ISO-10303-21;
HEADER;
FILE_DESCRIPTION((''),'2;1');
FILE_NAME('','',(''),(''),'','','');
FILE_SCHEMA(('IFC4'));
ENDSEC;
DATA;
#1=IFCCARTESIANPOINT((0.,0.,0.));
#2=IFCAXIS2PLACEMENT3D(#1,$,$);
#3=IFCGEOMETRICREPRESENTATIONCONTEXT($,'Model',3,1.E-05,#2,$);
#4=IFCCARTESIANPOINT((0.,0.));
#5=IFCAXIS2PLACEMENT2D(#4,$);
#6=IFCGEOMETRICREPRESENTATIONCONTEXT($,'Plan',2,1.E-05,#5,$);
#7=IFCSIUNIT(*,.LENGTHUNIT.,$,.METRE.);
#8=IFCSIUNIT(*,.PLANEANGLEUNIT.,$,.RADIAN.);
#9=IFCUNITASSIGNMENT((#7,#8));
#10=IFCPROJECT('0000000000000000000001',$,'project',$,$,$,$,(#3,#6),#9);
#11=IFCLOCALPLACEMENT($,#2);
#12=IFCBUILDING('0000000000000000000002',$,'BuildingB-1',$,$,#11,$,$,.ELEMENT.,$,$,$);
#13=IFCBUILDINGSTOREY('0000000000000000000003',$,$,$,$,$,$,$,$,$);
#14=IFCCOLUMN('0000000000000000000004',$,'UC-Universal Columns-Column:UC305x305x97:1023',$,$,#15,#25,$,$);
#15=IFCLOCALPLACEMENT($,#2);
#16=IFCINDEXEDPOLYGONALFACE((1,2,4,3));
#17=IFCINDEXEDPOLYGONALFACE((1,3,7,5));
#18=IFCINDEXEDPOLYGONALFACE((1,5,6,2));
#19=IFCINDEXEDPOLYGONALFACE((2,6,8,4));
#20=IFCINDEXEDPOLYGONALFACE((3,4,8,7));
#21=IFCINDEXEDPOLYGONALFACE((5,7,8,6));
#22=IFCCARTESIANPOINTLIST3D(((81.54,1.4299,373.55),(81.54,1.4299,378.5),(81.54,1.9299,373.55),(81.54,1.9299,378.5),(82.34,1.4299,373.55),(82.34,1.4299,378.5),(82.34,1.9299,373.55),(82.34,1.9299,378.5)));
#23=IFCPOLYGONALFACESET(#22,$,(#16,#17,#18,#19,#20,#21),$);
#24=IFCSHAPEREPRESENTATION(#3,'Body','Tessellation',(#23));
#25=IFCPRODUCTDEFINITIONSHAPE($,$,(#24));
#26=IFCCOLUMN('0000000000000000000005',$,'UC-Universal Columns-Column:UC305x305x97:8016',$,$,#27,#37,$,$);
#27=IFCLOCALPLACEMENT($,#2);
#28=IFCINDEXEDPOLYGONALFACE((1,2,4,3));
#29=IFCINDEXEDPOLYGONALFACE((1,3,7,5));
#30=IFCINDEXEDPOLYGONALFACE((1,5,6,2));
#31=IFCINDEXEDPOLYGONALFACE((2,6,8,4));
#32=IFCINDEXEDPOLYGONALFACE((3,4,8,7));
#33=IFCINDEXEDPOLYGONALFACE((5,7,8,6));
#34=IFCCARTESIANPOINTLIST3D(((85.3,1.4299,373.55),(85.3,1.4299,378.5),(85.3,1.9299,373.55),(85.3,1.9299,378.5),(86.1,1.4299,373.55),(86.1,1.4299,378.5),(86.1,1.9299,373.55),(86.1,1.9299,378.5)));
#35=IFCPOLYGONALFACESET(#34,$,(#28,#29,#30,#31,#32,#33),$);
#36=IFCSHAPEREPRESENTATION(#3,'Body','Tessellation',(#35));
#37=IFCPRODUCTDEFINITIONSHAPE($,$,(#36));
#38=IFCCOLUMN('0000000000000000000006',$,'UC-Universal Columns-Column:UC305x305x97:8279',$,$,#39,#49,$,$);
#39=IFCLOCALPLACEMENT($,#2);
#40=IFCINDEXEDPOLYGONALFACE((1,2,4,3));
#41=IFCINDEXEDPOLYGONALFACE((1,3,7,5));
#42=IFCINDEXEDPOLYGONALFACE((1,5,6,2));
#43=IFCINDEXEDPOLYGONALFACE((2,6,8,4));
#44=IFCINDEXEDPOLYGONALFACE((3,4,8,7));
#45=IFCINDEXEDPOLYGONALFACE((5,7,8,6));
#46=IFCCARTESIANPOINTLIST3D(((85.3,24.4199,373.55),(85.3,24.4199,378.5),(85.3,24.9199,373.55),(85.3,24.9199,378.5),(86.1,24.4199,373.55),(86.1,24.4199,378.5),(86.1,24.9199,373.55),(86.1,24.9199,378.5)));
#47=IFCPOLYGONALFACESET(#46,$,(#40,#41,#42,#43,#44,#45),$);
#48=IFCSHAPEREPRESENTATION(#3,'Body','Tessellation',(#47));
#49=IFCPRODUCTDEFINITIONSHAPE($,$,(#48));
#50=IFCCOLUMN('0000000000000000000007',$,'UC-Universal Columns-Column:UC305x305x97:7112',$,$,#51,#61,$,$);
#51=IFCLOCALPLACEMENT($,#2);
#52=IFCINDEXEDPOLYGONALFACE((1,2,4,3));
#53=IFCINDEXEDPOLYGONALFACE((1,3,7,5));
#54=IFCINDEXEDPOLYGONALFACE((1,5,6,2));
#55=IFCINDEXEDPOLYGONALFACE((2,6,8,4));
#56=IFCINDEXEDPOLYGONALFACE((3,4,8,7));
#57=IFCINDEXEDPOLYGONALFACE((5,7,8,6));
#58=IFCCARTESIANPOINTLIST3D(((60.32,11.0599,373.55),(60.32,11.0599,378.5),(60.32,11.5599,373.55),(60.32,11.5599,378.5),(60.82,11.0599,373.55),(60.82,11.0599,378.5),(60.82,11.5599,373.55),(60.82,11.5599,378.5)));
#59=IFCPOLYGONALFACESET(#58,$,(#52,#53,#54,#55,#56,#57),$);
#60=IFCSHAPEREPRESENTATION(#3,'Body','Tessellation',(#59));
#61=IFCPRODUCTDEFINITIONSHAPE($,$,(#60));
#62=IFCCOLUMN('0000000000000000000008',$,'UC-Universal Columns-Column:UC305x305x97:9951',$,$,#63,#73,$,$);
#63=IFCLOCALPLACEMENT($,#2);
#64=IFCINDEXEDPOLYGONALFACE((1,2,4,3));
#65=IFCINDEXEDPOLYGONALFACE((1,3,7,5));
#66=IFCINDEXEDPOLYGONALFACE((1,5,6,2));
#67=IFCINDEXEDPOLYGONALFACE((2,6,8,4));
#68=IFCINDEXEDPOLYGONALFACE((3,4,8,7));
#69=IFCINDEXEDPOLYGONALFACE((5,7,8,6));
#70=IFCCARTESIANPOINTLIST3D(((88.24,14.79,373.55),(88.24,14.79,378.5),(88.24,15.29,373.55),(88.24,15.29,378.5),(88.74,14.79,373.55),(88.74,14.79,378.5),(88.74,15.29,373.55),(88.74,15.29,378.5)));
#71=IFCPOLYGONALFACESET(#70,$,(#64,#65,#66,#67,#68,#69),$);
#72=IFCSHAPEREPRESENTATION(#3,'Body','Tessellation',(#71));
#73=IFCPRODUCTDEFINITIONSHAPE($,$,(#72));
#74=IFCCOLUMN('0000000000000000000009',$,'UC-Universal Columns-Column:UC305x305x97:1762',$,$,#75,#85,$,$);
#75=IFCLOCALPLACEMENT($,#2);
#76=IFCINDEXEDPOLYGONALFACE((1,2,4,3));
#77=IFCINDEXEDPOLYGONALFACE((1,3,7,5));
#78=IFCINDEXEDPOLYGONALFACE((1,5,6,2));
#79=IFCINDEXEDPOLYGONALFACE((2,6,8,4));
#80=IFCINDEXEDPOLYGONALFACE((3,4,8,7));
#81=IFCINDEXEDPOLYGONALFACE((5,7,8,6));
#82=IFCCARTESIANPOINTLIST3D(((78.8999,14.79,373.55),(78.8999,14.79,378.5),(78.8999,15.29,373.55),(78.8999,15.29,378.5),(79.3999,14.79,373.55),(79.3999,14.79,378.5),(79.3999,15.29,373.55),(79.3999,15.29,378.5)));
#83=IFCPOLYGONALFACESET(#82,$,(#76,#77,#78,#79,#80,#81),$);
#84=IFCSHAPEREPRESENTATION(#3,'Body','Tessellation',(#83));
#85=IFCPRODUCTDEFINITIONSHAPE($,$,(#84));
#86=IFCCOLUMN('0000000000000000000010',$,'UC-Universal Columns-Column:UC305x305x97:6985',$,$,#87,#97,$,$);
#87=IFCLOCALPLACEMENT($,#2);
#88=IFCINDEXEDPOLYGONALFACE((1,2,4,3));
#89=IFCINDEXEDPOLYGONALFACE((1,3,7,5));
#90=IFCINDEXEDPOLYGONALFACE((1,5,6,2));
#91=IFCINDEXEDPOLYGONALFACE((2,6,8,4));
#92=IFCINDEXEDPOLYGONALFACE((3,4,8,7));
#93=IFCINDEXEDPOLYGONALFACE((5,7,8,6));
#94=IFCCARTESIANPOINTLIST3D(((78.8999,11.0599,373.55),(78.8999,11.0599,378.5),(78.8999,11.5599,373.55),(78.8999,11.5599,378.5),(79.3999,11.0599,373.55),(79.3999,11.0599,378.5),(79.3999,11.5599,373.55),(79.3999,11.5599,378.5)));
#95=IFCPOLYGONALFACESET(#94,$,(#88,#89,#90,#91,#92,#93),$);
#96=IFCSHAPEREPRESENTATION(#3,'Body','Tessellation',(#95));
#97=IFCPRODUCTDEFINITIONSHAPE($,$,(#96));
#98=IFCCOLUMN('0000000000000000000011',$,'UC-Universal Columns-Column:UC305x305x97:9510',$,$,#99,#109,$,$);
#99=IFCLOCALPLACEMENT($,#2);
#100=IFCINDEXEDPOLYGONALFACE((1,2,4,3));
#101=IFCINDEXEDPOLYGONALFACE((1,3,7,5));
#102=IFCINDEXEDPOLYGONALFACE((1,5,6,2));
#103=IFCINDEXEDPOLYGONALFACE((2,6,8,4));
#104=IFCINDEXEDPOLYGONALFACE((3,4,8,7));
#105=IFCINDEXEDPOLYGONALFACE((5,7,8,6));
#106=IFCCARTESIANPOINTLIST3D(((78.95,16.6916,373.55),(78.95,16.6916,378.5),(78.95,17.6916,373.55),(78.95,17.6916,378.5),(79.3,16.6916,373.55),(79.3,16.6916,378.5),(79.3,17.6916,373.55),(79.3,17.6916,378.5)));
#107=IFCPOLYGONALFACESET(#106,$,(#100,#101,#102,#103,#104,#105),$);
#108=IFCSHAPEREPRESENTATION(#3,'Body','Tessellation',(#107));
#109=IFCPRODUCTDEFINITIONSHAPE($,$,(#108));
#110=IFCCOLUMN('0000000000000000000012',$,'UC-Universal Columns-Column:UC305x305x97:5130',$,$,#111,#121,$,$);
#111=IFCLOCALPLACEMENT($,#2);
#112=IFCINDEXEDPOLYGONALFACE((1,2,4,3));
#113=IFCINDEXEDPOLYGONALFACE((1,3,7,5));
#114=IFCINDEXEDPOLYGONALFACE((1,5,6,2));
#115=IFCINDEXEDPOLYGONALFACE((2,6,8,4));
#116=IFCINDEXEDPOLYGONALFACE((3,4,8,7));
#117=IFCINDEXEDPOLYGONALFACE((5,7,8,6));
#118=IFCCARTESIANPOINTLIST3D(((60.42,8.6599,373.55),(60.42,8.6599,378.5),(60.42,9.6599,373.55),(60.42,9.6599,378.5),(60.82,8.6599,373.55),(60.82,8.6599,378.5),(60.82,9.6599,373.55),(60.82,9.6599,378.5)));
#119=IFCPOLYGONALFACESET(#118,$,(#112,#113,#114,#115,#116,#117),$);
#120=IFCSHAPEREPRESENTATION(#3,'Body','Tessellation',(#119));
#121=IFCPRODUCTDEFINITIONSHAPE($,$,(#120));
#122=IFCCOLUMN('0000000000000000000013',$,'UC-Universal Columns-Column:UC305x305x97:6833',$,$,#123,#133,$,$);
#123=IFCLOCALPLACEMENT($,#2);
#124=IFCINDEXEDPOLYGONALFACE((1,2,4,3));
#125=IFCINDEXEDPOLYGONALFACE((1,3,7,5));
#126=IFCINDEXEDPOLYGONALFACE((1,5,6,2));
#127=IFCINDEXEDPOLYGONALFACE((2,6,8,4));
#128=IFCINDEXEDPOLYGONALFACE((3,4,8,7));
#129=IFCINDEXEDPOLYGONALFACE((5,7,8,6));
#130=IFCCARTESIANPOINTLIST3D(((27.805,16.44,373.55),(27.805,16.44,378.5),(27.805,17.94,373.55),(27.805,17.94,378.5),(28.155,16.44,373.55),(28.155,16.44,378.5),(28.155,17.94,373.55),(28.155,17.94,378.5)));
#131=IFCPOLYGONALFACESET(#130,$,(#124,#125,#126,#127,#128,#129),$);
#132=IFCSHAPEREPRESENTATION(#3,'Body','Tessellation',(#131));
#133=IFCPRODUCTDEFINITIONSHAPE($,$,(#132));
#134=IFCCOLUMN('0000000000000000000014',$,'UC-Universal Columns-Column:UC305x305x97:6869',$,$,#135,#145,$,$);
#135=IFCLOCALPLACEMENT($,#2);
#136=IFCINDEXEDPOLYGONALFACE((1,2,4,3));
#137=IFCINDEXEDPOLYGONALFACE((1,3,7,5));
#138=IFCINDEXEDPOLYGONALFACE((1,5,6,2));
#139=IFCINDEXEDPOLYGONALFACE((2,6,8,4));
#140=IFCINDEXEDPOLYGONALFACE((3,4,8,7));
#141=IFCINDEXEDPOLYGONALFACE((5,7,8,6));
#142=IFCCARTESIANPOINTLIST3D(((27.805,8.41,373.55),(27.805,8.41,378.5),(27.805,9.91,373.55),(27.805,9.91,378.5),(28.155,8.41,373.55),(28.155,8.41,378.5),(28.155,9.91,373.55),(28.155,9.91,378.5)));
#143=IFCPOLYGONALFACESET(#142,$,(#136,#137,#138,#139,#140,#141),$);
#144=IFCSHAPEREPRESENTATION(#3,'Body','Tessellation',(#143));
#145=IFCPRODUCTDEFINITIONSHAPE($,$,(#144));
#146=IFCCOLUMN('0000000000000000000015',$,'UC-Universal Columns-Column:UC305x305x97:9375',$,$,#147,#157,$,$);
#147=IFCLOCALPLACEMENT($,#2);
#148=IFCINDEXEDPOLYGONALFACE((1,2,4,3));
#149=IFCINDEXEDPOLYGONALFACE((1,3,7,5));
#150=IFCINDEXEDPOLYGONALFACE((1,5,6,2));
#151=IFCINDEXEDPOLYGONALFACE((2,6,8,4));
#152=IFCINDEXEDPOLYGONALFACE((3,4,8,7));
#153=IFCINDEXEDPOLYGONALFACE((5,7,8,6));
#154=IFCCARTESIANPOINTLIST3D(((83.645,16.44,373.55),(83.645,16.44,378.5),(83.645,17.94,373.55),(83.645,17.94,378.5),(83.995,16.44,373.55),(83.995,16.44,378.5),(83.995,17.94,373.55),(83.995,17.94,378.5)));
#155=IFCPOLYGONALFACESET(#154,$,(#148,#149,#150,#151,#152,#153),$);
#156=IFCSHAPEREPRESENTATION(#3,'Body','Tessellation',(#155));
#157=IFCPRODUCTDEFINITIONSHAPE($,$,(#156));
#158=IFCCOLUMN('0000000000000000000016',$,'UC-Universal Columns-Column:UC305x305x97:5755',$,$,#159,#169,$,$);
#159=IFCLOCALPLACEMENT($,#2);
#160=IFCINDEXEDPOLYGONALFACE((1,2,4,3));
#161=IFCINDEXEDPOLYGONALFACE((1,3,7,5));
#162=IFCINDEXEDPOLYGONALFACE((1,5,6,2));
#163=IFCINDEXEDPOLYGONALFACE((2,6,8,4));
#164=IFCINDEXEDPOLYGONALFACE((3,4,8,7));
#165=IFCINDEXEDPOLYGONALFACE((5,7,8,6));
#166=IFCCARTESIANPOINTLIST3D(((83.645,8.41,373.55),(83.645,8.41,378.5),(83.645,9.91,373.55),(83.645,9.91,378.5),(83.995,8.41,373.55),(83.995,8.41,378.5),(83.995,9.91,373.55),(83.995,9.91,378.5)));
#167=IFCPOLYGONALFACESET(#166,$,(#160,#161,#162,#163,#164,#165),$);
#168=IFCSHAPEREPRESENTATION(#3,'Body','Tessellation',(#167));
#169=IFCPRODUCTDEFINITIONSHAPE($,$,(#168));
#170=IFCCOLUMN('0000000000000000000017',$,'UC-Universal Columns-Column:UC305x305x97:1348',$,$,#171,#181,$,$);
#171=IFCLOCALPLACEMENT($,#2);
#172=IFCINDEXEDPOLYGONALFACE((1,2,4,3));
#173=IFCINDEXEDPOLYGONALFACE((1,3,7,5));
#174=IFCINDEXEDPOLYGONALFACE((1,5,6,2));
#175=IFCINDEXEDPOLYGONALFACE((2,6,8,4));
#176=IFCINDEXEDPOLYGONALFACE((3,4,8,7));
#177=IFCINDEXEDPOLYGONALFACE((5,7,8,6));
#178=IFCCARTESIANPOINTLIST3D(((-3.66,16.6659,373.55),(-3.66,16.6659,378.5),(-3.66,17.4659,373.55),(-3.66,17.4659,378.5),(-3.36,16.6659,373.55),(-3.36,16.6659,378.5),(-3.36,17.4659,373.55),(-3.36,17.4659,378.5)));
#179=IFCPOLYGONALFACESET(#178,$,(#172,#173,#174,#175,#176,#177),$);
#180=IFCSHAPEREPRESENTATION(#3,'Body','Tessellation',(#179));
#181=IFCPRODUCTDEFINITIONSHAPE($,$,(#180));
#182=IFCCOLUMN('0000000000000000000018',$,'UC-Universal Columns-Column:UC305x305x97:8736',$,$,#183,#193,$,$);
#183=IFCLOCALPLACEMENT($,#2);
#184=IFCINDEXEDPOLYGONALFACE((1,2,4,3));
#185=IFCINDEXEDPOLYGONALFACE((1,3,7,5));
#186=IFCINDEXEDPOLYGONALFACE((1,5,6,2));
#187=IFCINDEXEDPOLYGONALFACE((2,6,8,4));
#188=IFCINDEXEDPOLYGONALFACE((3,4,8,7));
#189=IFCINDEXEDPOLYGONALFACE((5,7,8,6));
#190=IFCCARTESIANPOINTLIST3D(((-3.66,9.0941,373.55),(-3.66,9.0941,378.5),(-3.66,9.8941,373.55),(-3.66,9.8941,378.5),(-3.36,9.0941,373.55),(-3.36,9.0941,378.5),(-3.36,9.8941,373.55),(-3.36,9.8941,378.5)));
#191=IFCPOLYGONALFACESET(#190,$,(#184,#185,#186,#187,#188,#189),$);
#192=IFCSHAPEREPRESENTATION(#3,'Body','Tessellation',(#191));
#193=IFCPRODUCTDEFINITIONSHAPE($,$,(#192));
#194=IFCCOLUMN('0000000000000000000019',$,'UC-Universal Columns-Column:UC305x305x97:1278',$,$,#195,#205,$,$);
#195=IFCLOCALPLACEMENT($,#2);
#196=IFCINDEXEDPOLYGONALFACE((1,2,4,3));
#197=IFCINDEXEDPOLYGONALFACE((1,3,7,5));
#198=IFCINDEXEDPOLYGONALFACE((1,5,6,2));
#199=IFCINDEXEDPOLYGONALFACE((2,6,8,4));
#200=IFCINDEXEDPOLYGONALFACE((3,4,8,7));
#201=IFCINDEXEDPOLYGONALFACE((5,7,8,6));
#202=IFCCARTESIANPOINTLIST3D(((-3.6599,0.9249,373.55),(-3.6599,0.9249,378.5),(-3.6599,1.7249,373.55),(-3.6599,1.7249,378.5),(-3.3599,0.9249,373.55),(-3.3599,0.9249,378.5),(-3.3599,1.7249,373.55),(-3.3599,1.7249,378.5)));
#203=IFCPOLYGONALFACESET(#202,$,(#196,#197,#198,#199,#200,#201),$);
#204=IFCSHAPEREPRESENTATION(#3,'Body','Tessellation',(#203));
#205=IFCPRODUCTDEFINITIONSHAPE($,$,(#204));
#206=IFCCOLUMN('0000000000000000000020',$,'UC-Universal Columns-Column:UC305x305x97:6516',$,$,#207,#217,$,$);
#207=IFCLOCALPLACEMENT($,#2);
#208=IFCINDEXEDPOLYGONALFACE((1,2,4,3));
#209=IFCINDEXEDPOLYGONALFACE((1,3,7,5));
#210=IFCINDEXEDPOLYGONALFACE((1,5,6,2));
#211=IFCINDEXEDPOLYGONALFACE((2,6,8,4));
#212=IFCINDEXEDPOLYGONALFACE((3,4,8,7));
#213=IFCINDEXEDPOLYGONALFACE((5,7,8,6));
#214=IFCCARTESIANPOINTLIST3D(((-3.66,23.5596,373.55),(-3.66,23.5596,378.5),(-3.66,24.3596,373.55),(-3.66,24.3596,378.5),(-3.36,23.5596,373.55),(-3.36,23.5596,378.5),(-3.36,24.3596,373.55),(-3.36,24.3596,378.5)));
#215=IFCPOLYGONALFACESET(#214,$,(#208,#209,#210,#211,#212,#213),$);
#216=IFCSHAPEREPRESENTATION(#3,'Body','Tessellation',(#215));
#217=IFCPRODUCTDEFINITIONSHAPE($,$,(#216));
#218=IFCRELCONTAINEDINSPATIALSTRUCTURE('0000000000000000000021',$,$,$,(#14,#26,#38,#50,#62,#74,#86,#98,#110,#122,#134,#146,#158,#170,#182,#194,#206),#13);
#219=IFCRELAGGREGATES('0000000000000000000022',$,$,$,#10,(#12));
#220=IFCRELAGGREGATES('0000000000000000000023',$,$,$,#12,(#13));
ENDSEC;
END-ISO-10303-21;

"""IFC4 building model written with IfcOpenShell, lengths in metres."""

from ifc_helpers import new_model, si_unit, origin, origin_2d, place, context, project, spatial, polyline, outline, extrude, element, save


model = new_model("IFC4")

# Units and contexts
model_context = context("Model", 3, precision=1e-05, world=origin())
plan_context = context("Plan", 2, precision=1e-05, world=origin_2d())
ifc_project = project(units=[si_unit("LENGTHUNIT", "METRE"), si_unit("PLANEANGLEUNIT", "RADIAN")], contexts=[model_context, plan_context])

# Building, storey
building_placement = place(None, origin())
building = spatial("IfcBuilding", under=ifc_project, at=building_placement, Name="BuildingB-1", CompositionType="ELEMENT")
storey = spatial("IfcBuildingStorey", under=building)

# Columns
element("IfcColumn", 1, inside=storey, Name="UC-Universal Columns-Column:UC305x305x97:1023", context=model_context, shape_type="SweptSolid", body=[
    extrude(outline(polyline([(81.54, 1.4299, 378.5), (82.34, 1.4299, 378.5), (82.34, 1.9299, 378.5), (81.54, 1.9299, 378.5), (81.54, 1.4299, 378.5)])), None, (0.0, 0.0, -1.0), 4.95),
])
element("IfcColumn", 2, inside=storey, Name="UC-Universal Columns-Column:UC305x305x97:8016", context=model_context, shape_type="SweptSolid", body=[
    extrude(outline(polyline([(86.1, 1.4299, 378.5), (85.3, 1.4299, 378.5), (85.3, 1.9299, 378.5), (86.1, 1.9299, 378.5), (86.1, 1.4299, 378.5)])), None, (0.0, 0.0, -1.0), 4.95),
])
element("IfcColumn", 3, inside=storey, Name="UC-Universal Columns-Column:UC305x305x97:8279", context=model_context, shape_type="SweptSolid", body=[
    extrude(outline(polyline([(86.1, 24.4199, 378.5), (85.3, 24.4199, 378.5), (85.3, 24.9199, 378.5), (86.1, 24.9199, 378.5), (86.1, 24.4199, 378.5)])), None, (0.0, 0.0, -1.0), 4.95),
])
element("IfcColumn", 4, inside=storey, Name="UC-Universal Columns-Column:UC305x305x97:7112", context=model_context, shape_type="SweptSolid", body=[
    extrude(outline(polyline([(60.82, 11.0599, 378.5), (60.32, 11.0599, 378.5), (60.32, 11.5599, 378.5), (60.82, 11.5599, 378.5), (60.82, 11.0599, 378.5)])), None, (0.0, 0.0, -1.0), 4.95),
])
element("IfcColumn", 5, inside=storey, Name="UC-Universal Columns-Column:UC305x305x97:9951", context=model_context, shape_type="SweptSolid", body=[
    extrude(outline(polyline([(88.74, 15.29, 378.5), (88.24, 15.29, 378.5), (88.24, 14.79, 378.5), (88.74, 14.79, 378.5), (88.74, 15.29, 378.5)])), None, (0.0, 0.0, -1.0), 4.95),
])
element("IfcColumn", 6, inside=storey, Name="UC-Universal Columns-Column:UC305x305x97:1762", context=model_context, shape_type="SweptSolid", body=[
    extrude(outline(polyline([(78.8999, 15.29, 378.5), (79.3999, 15.29, 378.5), (79.3999, 14.79, 378.5), (78.8999, 14.79, 378.5), (78.8999, 15.29, 378.5)])), None, (0.0, 0.0, -1.0), 4.95),
])
element("IfcColumn", 7, inside=storey, Name="UC-Universal Columns-Column:UC305x305x97:6985", context=model_context, shape_type="SweptSolid", body=[
    extrude(outline(polyline([(78.8999, 11.0599, 378.5), (79.3999, 11.0599, 378.5), (79.3999, 11.5599, 378.5), (78.8999, 11.5599, 378.5), (78.8999, 11.0599, 378.5)])), None, (0.0, 0.0, -1.0), 4.95),
])
element("IfcColumn", 8, inside=storey, Name="UC-Universal Columns-Column:UC305x305x97:9510", context=model_context, shape_type="SweptSolid", body=[
    extrude(outline(polyline([(79.3, 17.6916, 378.5), (78.95, 17.6916, 378.5), (78.95, 16.6916, 378.5), (79.3, 16.6916, 378.5), (79.3, 17.6916, 378.5)])), None, (0.0, 0.0, -1.0), 4.95),
])
element("IfcColumn", 9, inside=storey, Name="UC-Universal Columns-Column:UC305x305x97:5130", context=model_context, shape_type="SweptSolid", body=[
    extrude(outline(polyline([(60.42, 8.6599, 378.5), (60.82, 8.6599, 378.5), (60.82, 9.6599, 378.5), (60.42, 9.6599, 378.5), (60.42, 8.6599, 378.5)])), None, (0.0, 0.0, -1.0), 4.95),
])
element("IfcColumn", 10, inside=storey, Name="UC-Universal Columns-Column:UC305x305x97:6833", context=model_context, shape_type="SweptSolid", body=[
    extrude(outline(polyline([(28.155, 17.94, 378.5), (27.805, 17.94, 378.5), (27.805, 16.44, 378.5), (28.155, 16.44, 378.5), (28.155, 17.94, 378.5)])), None, (0.0, 0.0, -1.0), 4.95),
])
element("IfcColumn", 11, inside=storey, Name="UC-Universal Columns-Column:UC305x305x97:6869", context=model_context, shape_type="SweptSolid", body=[
    extrude(outline(polyline([(28.155, 9.91, 378.5), (27.805, 9.91, 378.5), (27.805, 8.41, 378.5), (28.155, 8.41, 378.5), (28.155, 9.91, 378.5)])), None, (0.0, 0.0, -1.0), 4.95),
])
element("IfcColumn", 12, inside=storey, Name="UC-Universal Columns-Column:UC305x305x97:9375", context=model_context, shape_type="SweptSolid", body=[
    extrude(outline(polyline([(83.995, 17.94, 378.5), (83.645, 17.94, 378.5), (83.645, 16.44, 378.5), (83.995, 16.44, 378.5), (83.995, 17.94, 378.5)])), None, (0.0, 0.0, -1.0), 4.95),
])
element("IfcColumn", 13, inside=storey, Name="UC-Universal Columns-Column:UC305x305x97:5755", context=model_context, shape_type="SweptSolid", body=[
    extrude(outline(polyline([(83.995, 9.91, 378.5), (83.645, 9.91, 378.5), (83.645, 8.41, 378.5), (83.995, 8.41, 378.5), (83.995, 9.91, 378.5)])), None, (0.0, 0.0, -1.0), 4.95),
])
element("IfcColumn", 14, inside=storey, Name="UC-Universal Columns-Column:UC305x305x97:1348", context=model_context, shape_type="SweptSolid", body=[
    extrude(outline(polyline([(-3.36, 17.4659, 378.5), (-3.66, 17.4659, 378.5), (-3.66, 16.6659, 378.5), (-3.36, 16.6659, 378.5), (-3.36, 17.4659, 378.5)])), None, (0.0, 0.0, -1.0), 4.95),
])
element("IfcColumn", 15, inside=storey, Name="UC-Universal Columns-Column:UC305x305x97:8736", context=model_context, shape_type="SweptSolid", body=[
    extrude(outline(polyline([(-3.36, 9.8941, 378.5), (-3.66, 9.8941, 378.5), (-3.66, 9.0941, 378.5), (-3.36, 9.0941, 378.5), (-3.36, 9.8941, 378.5)])), None, (0.0, 0.0, -1.0), 4.95),
])
element("IfcColumn", 16, inside=storey, Name="UC-Universal Columns-Column:UC305x305x97:1278", context=model_context, shape_type="SweptSolid", body=[
    extrude(outline(polyline([(-3.3599, 1.7249, 378.5), (-3.6599, 1.7249, 378.5), (-3.6599, 0.9249, 378.5), (-3.3599, 0.9249, 378.5), (-3.3599, 1.7249, 378.5)])), None, (0.0, 0.0, -1.0), 4.95),
])
element("IfcColumn", 17, inside=storey, Name="UC-Universal Columns-Column:UC305x305x97:6516", context=model_context, shape_type="SweptSolid", body=[
    extrude(outline(polyline([(-3.66, 23.5596, 378.5), (-3.36, 23.5596, 378.5), (-3.36, 24.3596, 378.5), (-3.66, 24.3596, 378.5), (-3.66, 23.5596, 378.5)])), None, (0.0, 0.0, -1.0), 4.95),
])

save(model, "model.ifc")
